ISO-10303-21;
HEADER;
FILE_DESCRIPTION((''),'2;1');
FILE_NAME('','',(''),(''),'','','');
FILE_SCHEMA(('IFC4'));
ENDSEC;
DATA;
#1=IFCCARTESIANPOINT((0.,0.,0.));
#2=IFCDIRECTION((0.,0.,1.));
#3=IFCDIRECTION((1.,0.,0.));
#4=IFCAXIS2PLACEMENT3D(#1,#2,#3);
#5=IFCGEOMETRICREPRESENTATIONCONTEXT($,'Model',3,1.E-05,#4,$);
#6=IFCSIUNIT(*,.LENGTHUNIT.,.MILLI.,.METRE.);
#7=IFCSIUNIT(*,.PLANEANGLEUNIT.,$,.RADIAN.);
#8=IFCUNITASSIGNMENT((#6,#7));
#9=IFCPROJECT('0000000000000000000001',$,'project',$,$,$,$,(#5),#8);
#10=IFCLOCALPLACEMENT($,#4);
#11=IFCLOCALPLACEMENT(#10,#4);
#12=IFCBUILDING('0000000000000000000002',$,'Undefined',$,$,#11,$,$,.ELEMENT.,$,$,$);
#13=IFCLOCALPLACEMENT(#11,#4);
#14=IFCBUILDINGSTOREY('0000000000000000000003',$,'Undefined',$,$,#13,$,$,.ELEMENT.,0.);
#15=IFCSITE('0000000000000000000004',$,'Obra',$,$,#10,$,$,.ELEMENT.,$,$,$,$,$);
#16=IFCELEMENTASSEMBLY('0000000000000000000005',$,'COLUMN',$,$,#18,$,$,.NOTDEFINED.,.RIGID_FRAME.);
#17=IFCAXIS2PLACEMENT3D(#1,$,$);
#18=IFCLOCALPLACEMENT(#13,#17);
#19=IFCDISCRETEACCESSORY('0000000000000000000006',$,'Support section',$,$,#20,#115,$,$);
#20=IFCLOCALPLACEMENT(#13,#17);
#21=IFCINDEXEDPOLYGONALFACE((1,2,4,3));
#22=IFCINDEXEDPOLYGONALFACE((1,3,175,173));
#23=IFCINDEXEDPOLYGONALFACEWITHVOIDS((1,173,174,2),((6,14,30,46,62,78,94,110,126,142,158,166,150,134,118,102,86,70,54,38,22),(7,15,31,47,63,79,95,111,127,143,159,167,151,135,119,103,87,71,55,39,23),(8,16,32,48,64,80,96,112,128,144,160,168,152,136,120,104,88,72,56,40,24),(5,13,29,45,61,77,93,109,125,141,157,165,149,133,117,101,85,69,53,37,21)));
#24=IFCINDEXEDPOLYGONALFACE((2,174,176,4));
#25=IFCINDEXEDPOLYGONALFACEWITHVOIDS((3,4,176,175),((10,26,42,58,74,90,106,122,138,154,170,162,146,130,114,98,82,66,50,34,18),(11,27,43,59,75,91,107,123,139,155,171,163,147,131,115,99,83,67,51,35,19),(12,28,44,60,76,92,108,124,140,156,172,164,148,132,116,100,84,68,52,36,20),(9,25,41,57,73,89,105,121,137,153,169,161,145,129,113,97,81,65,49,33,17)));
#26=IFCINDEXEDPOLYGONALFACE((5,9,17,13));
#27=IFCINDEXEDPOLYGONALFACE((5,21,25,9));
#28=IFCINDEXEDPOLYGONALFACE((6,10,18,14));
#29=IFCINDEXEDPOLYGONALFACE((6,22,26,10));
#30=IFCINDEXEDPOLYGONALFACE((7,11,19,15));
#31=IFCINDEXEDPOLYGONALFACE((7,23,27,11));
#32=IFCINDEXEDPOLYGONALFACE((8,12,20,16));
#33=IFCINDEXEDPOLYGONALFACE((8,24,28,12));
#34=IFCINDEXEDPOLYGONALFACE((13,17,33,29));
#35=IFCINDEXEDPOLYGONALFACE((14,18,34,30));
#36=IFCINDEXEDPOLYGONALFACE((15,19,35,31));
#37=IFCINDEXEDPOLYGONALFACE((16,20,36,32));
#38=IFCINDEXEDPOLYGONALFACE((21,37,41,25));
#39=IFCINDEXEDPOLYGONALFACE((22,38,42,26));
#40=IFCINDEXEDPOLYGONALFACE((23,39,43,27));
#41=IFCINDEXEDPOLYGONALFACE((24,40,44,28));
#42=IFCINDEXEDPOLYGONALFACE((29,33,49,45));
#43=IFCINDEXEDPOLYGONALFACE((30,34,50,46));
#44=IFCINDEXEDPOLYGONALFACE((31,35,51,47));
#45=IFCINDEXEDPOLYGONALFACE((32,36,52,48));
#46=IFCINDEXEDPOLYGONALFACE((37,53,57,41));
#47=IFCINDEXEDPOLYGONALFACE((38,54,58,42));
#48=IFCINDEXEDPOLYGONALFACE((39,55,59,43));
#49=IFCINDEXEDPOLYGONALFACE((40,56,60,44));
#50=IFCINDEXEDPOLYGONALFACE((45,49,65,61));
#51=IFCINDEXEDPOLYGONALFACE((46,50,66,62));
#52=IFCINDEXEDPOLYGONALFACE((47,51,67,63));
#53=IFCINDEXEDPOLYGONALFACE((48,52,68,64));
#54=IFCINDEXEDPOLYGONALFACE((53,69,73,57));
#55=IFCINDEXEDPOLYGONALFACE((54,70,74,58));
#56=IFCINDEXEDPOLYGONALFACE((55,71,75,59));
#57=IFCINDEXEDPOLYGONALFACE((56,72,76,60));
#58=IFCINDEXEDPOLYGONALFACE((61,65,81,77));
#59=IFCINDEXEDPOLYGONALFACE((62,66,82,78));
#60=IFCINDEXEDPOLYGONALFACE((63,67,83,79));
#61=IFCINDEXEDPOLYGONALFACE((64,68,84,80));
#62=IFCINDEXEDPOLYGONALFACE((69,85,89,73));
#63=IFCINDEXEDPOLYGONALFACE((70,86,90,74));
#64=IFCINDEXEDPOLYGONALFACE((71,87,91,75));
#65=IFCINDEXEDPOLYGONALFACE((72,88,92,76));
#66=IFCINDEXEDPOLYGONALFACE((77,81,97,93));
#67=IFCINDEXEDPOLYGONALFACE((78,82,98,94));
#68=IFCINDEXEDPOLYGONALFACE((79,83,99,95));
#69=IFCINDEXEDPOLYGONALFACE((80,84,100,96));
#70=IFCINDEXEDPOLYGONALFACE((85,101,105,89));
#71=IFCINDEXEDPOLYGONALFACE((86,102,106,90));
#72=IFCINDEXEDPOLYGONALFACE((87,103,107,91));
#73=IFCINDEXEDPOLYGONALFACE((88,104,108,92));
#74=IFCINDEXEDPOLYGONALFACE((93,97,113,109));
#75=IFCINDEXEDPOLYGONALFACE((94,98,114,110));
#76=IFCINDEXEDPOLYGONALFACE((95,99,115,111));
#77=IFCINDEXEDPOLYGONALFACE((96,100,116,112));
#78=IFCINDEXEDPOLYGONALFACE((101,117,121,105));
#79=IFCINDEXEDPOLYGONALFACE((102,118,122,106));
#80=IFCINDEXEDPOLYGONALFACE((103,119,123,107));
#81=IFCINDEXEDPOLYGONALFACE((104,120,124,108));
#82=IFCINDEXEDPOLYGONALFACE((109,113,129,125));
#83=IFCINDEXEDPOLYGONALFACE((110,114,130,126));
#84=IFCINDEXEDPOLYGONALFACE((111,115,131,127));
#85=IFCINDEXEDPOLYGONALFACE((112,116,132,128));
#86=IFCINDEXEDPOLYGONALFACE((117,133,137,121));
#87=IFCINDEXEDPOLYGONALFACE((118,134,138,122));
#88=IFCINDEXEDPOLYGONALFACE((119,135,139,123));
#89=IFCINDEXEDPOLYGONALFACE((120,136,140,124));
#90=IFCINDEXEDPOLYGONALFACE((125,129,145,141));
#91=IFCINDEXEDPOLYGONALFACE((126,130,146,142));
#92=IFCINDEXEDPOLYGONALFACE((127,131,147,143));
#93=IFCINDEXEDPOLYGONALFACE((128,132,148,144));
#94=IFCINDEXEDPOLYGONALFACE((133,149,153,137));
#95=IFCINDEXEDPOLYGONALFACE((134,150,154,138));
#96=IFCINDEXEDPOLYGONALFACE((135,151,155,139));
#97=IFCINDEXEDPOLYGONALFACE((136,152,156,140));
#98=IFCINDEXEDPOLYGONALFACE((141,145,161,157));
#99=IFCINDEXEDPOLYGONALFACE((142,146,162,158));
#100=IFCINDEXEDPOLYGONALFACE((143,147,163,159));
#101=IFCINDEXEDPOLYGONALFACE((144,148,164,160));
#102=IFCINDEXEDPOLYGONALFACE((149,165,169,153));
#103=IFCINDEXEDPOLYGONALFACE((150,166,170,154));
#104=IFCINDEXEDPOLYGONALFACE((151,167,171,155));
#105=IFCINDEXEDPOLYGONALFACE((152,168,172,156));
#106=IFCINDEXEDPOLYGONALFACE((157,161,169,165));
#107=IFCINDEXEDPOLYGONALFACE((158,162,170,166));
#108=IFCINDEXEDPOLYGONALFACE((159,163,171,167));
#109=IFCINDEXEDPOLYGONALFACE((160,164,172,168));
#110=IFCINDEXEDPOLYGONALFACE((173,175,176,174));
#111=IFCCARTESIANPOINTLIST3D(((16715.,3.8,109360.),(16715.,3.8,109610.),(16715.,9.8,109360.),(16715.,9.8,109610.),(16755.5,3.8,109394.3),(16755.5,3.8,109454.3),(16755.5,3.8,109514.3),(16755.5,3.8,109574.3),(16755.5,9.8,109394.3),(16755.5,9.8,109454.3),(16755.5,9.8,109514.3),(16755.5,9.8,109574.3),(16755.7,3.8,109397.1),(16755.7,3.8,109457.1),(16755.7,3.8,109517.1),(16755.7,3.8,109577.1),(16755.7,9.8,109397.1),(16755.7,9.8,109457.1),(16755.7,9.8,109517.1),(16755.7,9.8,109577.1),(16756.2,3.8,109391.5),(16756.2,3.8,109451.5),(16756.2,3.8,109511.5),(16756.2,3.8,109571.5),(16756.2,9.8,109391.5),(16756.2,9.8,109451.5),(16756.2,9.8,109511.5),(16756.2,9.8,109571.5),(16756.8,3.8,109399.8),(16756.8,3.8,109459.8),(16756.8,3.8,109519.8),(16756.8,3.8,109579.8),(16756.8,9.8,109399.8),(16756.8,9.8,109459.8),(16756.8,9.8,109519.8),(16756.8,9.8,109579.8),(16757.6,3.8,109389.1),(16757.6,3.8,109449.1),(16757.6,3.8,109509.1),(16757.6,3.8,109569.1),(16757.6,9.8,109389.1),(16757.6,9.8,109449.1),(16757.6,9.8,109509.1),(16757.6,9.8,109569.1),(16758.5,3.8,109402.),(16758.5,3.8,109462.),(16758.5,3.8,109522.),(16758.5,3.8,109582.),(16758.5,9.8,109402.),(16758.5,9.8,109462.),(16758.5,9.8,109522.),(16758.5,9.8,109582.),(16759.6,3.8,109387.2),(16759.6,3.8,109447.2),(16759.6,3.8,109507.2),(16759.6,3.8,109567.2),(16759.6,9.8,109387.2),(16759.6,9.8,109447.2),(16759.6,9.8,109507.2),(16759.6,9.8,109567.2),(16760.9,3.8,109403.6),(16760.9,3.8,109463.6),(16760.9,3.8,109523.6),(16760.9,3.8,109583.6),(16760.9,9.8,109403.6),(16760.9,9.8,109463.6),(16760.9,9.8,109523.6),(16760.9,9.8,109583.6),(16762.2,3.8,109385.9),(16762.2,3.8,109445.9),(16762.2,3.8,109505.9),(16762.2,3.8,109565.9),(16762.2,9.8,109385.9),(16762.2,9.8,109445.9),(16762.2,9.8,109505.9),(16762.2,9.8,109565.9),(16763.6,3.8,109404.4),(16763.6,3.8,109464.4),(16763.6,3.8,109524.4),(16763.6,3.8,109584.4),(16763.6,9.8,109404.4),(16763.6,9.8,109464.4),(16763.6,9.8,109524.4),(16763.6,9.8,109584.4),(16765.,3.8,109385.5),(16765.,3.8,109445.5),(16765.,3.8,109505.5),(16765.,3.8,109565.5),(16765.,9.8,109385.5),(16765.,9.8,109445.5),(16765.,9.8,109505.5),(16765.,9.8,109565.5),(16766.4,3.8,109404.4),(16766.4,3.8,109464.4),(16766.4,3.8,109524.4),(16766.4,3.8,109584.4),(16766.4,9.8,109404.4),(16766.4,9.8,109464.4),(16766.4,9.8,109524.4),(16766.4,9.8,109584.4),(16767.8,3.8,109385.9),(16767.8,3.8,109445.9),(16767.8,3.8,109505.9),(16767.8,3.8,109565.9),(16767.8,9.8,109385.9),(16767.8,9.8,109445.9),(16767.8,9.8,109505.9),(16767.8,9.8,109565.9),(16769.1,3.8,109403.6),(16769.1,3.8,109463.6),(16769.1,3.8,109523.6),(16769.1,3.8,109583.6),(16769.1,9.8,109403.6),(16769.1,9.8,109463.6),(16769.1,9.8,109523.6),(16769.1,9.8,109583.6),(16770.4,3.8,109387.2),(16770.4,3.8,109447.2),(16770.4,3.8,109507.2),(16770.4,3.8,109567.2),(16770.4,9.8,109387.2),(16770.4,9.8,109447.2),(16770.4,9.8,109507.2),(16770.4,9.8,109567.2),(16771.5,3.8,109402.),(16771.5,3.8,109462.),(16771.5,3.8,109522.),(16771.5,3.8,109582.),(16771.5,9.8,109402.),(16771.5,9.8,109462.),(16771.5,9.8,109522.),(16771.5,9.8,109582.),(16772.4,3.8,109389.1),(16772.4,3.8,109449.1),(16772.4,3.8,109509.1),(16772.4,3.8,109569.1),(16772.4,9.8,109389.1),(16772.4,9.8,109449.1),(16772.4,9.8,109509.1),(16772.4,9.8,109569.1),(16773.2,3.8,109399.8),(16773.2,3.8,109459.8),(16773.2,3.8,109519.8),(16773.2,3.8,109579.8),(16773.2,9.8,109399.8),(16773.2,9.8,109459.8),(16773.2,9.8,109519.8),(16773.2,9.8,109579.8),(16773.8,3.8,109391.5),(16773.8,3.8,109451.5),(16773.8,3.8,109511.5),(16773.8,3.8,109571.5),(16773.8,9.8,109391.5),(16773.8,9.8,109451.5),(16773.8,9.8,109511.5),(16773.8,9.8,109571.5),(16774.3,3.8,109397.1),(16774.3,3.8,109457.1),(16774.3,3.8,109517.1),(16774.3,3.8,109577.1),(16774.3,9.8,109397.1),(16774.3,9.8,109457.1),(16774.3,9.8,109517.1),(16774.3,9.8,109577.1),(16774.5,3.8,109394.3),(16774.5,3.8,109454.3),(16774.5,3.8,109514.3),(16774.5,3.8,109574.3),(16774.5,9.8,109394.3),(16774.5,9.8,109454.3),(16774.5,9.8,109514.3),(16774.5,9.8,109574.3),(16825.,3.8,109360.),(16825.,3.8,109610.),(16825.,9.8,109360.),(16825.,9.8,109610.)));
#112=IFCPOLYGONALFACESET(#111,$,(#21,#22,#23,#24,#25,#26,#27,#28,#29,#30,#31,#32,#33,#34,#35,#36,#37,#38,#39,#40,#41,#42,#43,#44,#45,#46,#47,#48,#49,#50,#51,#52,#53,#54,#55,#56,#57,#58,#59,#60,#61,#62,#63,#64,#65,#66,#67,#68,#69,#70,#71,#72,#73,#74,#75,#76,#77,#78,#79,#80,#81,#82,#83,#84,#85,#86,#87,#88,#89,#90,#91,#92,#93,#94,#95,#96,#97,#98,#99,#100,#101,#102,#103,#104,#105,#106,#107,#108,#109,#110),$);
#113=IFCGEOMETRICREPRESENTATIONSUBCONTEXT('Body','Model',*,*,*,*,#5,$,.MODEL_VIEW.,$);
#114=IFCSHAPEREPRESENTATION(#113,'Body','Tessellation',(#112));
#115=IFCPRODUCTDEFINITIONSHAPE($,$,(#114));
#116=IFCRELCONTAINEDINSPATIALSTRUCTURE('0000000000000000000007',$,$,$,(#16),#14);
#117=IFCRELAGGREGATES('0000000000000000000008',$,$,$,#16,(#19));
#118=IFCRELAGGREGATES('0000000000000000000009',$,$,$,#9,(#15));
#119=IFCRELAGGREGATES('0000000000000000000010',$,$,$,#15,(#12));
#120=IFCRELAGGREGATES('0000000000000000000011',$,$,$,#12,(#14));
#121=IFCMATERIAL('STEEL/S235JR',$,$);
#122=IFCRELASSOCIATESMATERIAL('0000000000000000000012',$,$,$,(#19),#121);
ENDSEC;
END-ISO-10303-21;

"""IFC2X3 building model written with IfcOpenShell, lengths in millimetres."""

from ifc_helpers import new_model, si_unit, frame, origin_with_axes, origin_2d_with_axis, place, context, subcontext, project, spatial, rectangle, circle, extrude, source, transform, mapped, material, element, aggregate, save


model = new_model("IFC2X3")

# Units and contexts
model_context = context("Model", 3, precision=1e-05, world=origin_with_axes())
body_context = subcontext(model_context, "Body", "Model", "MODEL_VIEW")
ifc_project = project(units=[si_unit("LENGTHUNIT", "METRE", prefix="MILLI"), si_unit("PLANEANGLEUNIT", "RADIAN")], contexts=[model_context])

# Site, building, storey
site_placement = place(None, origin_with_axes())
site = spatial("IfcSite", under=ifc_project, at=site_placement, Name="Obra", CompositionType="ELEMENT")
building_placement = place(site_placement, origin_with_axes())
building = spatial("IfcBuilding", under=site, at=building_placement, Name="Undefined", CompositionType="ELEMENT")
storey_placement = place(building_placement, origin_with_axes())
storey = spatial("IfcBuildingStorey", under=building, at=storey_placement, Name="Undefined", CompositionType="ELEMENT", Elevation=0.0)

# Shared definitions
ifc_material_1 = material(Name="STEEL/S235JR")

# Element assembly, discrete accessory, opening
assembly_1_placement = place(storey_placement, origin_with_axes())
assembly_1 = element("IfcElementAssembly", 1, at=assembly_1_placement, inside=storey, Name="COLUMN", AssemblyPlace="NOTDEFINED", PredefinedType="RIGID_FRAME")
shared_shape_1 = source(origin_with_axes(), body_context, "Body", "SweptSolid", [
    extrude(circle(Radius=9.5, at=origin_2d_with_axis()), frame((0.0, -9.9, 0.0), z_axis=(0.0, 1.0, 0.0), x_axis=(1.0, 0.0, 0.0)), (0.0, 0.0, 1.0), 6.2),
])
discrete_accessory_1_placement = place(assembly_1_placement, frame((16770.0, 6.8, 109360.0), z_axis=(0.0, 0.0, 1.0), x_axis=(1.0, 0.0, 0.0)))
discrete_accessory_1 = element("IfcDiscreteAccessory", 2, at=discrete_accessory_1_placement, material=ifc_material_1, Name="Support section", context=body_context, shape_type="SweptSolid", body=[
    extrude(rectangle(XDim=6.0, YDim=110.0, at=origin_2d_with_axis()), frame((0.0, 0.0, 250.0), z_axis=(0.0, 0.0, -1.0), x_axis=(0.0, 1.0, 0.0)), (0.0, 0.0, 1.0), 250.0),
])
opening_1_placement = place(assembly_1_placement, frame((16815.0, 0.0, 109650.0), z_axis=(-1.0, 0.0, 0.0), x_axis=(0.0, 0.0, -1.0)))
element("IfcOpeningElement", 3, at=opening_1_placement, cuts=discrete_accessory_1, ObjectType="Opening", context=body_context, shape_type="MappedRepresentation", body=[
    mapped(shared_shape_1, transform((75.0, 0.0, 50.0))),
    mapped(shared_shape_1, transform((135.0, 0.0, 50.0))),
    mapped(shared_shape_1, transform((195.0, 0.0, 50.0))),
    mapped(shared_shape_1, transform((255.0, 0.0, 50.0))),
])
aggregate(assembly_1, [discrete_accessory_1])

save(model, "model.ifc")
